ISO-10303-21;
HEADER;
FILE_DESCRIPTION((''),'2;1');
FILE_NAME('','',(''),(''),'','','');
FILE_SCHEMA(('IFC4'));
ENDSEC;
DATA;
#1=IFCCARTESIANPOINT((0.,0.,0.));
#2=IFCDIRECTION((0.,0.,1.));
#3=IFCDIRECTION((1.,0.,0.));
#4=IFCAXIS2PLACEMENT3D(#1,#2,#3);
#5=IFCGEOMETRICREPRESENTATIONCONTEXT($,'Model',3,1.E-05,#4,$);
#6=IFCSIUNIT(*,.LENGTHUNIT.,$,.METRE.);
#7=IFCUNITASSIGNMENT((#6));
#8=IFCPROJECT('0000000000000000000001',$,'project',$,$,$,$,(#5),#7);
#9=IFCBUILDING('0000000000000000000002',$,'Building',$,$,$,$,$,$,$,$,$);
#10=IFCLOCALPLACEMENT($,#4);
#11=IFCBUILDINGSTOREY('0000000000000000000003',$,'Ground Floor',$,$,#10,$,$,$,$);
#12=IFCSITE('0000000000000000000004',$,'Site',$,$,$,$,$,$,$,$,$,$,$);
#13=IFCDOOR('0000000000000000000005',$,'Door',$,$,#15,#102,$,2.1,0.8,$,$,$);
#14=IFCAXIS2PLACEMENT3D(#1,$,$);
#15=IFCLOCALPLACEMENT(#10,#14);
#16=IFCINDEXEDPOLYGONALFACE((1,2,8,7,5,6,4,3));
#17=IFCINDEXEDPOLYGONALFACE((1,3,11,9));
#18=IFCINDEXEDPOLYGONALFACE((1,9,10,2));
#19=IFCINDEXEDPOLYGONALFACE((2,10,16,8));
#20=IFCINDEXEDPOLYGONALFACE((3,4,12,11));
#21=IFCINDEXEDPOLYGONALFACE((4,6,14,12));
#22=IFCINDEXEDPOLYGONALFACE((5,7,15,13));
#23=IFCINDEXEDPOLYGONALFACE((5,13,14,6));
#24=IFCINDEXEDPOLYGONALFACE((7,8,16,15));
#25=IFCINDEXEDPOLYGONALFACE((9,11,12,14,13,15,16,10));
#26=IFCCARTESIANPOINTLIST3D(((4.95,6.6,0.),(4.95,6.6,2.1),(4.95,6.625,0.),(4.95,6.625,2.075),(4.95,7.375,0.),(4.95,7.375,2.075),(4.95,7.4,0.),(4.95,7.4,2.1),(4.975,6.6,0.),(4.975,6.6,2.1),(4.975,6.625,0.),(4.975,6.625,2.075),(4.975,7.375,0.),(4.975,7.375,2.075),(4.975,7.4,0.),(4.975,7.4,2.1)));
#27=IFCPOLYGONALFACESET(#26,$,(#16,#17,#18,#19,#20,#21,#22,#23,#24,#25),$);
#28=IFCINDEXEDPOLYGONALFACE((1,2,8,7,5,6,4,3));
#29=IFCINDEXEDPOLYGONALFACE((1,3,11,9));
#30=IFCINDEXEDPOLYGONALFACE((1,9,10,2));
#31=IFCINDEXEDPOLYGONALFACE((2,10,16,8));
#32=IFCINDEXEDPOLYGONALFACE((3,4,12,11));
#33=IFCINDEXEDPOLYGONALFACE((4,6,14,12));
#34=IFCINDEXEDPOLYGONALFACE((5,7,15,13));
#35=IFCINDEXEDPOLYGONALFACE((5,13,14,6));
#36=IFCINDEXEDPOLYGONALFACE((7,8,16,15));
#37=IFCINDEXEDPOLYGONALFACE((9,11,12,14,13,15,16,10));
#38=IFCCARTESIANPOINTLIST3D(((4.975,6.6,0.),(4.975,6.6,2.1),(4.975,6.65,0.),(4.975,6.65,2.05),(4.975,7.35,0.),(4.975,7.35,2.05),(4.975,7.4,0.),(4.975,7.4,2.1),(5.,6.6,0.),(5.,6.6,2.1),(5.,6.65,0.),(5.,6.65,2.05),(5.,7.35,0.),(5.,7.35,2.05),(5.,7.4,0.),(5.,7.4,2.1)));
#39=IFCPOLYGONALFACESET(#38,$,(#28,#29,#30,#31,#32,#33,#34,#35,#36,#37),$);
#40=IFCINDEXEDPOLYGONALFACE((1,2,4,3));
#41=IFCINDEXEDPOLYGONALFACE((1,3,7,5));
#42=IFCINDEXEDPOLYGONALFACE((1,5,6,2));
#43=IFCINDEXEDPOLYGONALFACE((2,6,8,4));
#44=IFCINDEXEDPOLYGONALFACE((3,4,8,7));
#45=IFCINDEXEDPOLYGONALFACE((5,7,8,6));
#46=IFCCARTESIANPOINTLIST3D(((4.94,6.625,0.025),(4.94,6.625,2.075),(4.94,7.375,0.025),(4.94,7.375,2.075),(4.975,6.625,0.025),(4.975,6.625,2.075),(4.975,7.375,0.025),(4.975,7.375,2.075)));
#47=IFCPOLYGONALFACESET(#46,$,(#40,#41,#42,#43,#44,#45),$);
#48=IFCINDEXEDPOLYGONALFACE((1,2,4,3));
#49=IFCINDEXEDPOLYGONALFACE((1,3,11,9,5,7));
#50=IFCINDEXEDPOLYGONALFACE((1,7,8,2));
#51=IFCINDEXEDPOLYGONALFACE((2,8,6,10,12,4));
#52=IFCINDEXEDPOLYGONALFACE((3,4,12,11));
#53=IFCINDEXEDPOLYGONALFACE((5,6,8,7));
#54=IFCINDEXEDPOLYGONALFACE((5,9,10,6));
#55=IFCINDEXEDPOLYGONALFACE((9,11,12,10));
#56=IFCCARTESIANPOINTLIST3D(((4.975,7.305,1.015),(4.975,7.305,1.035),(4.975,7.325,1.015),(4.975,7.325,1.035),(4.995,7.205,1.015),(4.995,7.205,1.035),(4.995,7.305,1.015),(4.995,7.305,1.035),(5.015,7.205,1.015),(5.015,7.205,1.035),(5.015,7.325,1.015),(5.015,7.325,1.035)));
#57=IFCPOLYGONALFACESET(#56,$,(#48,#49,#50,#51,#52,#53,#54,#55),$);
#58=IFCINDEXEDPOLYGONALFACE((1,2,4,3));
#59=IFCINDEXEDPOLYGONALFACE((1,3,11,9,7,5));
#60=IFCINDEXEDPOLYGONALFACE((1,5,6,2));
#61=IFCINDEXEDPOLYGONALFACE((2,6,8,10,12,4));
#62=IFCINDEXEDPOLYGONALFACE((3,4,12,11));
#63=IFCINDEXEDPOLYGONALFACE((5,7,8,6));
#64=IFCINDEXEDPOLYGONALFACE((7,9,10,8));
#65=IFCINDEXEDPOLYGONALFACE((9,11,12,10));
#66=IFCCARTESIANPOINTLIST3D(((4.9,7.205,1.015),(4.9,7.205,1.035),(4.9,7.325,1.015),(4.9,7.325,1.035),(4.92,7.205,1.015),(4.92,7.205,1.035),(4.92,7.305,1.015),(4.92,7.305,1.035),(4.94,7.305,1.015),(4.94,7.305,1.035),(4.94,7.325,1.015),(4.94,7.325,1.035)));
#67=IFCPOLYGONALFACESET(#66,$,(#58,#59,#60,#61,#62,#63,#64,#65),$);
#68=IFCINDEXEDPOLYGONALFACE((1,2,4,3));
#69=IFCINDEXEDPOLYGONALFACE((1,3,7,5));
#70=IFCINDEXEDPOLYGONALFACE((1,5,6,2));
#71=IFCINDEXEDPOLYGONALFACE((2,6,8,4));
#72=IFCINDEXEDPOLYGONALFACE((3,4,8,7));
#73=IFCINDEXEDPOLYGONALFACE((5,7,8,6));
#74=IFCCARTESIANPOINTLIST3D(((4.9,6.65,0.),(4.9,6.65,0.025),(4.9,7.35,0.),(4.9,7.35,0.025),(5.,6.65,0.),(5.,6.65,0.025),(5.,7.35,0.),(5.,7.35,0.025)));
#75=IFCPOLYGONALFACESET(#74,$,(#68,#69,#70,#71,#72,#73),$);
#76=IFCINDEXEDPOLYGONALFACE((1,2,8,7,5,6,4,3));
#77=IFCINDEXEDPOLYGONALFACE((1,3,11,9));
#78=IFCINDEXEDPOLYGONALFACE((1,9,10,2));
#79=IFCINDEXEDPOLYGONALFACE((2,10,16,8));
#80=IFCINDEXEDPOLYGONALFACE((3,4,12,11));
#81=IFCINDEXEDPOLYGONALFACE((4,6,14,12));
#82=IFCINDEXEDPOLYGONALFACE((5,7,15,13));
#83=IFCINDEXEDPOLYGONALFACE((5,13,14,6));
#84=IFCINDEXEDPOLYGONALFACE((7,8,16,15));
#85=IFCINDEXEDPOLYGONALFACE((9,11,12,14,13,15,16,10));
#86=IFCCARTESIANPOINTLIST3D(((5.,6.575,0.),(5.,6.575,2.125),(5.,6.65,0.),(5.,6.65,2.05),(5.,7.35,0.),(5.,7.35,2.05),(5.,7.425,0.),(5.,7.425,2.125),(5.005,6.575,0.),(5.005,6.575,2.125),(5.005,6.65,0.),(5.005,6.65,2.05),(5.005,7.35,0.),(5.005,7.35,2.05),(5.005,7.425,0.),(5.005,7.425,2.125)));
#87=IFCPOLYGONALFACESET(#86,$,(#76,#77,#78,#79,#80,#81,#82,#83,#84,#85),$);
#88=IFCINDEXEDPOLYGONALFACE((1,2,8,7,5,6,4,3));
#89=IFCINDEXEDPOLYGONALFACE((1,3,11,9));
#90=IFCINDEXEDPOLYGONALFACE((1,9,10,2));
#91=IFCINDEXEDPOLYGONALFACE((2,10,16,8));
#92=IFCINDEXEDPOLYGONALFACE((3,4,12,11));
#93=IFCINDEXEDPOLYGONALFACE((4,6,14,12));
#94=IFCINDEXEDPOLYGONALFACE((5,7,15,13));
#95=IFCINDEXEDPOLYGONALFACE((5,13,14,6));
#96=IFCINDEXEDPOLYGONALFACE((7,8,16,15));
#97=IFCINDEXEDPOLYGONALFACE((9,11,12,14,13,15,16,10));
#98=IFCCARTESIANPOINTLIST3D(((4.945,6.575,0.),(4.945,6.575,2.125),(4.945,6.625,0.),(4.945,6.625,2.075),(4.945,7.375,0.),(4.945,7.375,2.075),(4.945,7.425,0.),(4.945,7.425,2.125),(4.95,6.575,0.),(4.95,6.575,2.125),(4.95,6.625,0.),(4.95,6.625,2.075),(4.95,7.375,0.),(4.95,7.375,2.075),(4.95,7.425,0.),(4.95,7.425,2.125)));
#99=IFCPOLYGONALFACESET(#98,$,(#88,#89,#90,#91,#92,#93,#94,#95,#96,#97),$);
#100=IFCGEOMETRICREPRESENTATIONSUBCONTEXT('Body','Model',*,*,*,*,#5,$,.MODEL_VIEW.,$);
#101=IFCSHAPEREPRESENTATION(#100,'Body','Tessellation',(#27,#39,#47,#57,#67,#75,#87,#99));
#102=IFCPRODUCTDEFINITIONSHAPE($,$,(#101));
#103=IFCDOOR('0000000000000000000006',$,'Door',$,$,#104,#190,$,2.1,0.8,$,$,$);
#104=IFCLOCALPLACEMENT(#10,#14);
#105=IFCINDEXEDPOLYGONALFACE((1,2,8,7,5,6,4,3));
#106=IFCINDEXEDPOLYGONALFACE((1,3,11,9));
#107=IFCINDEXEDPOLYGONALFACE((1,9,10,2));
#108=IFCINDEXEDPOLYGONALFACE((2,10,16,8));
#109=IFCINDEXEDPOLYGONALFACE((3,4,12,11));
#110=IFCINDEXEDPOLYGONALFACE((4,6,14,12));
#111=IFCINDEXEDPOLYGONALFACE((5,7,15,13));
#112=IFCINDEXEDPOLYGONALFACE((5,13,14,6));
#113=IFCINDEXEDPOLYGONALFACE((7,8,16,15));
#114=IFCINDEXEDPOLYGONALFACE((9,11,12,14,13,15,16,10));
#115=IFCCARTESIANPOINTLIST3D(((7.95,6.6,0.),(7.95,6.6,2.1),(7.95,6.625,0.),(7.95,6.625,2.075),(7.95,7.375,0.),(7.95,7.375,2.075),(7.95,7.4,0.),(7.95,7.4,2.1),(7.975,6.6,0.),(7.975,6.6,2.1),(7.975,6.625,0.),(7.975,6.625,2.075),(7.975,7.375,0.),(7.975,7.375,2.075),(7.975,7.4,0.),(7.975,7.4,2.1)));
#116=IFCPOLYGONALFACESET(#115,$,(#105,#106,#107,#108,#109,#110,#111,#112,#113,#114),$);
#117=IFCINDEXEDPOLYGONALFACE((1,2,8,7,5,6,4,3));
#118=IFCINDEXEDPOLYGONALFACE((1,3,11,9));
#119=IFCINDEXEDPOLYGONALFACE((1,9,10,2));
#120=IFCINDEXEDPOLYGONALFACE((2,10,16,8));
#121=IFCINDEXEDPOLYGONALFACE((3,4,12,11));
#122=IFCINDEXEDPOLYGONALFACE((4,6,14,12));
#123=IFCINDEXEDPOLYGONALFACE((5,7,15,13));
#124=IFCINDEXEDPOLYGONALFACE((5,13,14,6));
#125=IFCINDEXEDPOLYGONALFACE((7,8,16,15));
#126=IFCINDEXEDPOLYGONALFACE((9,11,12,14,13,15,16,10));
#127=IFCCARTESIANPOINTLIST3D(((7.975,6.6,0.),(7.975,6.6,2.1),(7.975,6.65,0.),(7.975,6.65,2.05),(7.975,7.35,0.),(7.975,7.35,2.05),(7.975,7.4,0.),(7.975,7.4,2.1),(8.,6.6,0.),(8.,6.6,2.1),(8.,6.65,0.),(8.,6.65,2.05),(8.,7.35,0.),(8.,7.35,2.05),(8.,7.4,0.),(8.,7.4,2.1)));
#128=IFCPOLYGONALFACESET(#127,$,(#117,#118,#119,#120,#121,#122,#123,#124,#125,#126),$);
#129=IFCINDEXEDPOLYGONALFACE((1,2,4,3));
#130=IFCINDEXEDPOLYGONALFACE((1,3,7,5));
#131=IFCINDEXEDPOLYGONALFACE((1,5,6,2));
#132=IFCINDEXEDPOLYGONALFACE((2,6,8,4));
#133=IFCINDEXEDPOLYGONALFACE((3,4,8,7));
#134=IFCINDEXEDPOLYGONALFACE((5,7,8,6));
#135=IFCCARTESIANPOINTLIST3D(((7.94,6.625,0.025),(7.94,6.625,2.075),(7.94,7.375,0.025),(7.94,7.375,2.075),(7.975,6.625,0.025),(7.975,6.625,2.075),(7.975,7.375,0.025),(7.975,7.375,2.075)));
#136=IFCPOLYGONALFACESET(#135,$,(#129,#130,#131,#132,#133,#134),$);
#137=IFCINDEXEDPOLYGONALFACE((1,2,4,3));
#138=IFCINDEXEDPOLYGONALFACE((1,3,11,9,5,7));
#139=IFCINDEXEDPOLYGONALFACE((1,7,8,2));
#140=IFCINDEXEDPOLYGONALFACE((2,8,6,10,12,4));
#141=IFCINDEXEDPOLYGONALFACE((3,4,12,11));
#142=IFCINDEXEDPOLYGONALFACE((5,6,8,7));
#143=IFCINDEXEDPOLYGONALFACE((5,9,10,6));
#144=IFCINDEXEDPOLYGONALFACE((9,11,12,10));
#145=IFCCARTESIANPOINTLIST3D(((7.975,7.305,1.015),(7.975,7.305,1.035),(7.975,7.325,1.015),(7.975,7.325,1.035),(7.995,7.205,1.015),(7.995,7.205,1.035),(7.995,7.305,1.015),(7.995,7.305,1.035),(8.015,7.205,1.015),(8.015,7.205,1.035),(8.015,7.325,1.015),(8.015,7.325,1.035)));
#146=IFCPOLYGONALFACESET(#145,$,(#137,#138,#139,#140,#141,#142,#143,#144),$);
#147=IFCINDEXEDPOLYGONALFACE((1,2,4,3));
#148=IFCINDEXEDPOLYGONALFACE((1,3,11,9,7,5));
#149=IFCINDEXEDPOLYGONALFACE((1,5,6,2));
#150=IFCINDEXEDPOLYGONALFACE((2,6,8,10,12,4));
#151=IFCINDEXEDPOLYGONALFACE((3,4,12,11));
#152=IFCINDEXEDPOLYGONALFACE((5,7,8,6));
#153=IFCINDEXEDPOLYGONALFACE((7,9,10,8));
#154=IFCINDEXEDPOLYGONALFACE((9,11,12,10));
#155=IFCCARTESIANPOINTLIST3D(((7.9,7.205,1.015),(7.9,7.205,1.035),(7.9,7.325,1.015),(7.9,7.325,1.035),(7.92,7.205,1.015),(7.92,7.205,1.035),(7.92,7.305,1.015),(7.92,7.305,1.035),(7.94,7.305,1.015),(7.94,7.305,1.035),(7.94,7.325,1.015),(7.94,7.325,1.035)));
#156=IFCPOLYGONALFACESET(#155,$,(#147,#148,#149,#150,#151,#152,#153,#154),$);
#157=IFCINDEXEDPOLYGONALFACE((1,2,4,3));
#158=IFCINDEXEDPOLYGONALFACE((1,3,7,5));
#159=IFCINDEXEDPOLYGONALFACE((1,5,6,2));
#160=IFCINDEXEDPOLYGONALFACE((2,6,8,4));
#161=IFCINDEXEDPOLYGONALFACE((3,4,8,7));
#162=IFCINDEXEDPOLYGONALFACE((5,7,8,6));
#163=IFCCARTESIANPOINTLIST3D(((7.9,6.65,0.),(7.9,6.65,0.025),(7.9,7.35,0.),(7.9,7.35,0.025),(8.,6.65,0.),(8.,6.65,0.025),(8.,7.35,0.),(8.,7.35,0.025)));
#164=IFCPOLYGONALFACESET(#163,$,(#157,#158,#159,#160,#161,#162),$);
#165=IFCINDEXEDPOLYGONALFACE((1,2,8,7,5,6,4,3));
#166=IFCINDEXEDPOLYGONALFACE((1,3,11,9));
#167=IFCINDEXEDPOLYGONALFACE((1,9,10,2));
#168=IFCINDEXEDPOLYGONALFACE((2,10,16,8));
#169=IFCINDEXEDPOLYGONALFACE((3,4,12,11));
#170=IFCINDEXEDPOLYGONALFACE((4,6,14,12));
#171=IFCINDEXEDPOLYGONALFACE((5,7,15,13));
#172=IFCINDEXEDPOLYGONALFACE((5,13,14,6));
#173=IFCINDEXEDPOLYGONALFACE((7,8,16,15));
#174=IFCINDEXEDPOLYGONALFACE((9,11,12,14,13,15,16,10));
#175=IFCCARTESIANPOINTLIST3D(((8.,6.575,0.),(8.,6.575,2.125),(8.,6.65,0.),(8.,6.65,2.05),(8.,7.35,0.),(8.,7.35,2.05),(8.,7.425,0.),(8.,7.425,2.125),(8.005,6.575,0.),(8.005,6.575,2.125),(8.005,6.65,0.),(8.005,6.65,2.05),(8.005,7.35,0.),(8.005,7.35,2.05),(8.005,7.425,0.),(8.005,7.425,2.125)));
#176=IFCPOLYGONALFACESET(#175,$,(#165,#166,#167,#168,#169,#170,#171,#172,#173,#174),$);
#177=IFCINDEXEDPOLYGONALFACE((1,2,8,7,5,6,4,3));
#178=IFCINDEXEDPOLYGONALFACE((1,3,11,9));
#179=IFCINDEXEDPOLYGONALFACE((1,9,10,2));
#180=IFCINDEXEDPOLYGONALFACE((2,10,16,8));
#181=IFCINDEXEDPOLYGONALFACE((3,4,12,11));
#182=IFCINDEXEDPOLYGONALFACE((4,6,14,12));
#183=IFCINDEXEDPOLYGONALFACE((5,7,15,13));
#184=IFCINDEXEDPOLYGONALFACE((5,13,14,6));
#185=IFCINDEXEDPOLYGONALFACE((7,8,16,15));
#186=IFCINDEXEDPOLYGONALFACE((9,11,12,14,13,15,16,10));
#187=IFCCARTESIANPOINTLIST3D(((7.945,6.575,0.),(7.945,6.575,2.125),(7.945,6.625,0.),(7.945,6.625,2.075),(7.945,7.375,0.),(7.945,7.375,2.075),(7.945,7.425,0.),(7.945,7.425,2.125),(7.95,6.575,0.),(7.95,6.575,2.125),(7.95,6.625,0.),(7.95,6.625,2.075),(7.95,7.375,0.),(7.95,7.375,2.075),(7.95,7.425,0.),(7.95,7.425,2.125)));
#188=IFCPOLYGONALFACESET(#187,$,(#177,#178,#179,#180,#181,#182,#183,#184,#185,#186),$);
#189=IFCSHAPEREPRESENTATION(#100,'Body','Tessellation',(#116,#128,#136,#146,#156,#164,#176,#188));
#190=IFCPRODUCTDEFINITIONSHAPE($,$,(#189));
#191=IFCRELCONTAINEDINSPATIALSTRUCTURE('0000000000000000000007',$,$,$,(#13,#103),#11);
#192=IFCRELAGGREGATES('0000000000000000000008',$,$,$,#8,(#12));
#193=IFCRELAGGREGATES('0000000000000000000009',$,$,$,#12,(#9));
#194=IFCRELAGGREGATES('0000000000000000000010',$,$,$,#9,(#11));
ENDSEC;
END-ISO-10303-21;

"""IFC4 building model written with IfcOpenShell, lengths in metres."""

from ifc_helpers import new_model, si_unit, frame, origin_with_axes, place, context, subcontext, project, spatial, line, indexed_curve, outline, extrude, element, save


model = new_model("IFC4")

# Units and contexts
model_context = context("Model", 3, precision=1e-05, world=origin_with_axes())
body_context = subcontext(model_context, "Body", "Model", "MODEL_VIEW")
ifc_project = project(units=[si_unit("LENGTHUNIT", "METRE")], contexts=[model_context])

# Site, building, storey
site = spatial("IfcSite", under=ifc_project, Name="Site")
building = spatial("IfcBuilding", under=site, Name="Building")
storey_placement = place(None, origin_with_axes())
storey = spatial("IfcBuildingStorey", under=building, at=storey_placement, Name="Ground Floor")

# Doors
door_1_placement = place(storey_placement, frame((5.0, 6.6, 0.0), z_axis=(0.0, 0.0, 1.0), x_axis=(0.0, 1.0, 0.0)))
element("IfcDoor", 1, at=door_1_placement, inside=storey, Name="Door", OverallHeight=2.1, OverallWidth=0.8, context=body_context, shape_type="SweptSolid", body=[
    extrude(outline(indexed_curve([(0.0, 0.0), (0.0, 2.1), (0.8, 2.1), (0.8, 0.0), (0.775, 0.0), (0.775, 2.075), (0.025, 2.075), (0.025, 0.0)], segments=[line(1, 2, 3, 4, 5, 6, 7, 8, 1)])), frame((0.0, 0.025, 0.0), z_axis=(0.0, -1.0, 0.0), x_axis=(1.0, 0.0, 0.0)), (0.0, 0.0, -1.0), 0.025),
    extrude(outline(indexed_curve([(0.0, 0.0), (0.0, 2.1), (0.8, 2.1), (0.8, 0.0), (0.75, 0.0), (0.75, 2.05), (0.05, 2.05), (0.05, 0.0)], segments=[line(1, 2, 3, 4, 5, 6, 7, 8, 1)])), frame((0.0, 0.0, 0.0), z_axis=(0.0, -1.0, 0.0), x_axis=(1.0, 0.0, 0.0)), (0.0, 0.0, -1.0), 0.025),
    extrude(outline(indexed_curve([(0.0, 0.0), (0.75, 0.0), (0.75, 0.035), (0.0, 0.035)], segments=[line(1, 2, 3, 4, 1)])), frame((0.025, 0.025, 0.025), z_axis=(0.0, 0.0, 1.0), x_axis=(1.0, 0.0, 0.0)), (0.0, 0.0, 1.0), 2.05),
    extrude(outline(indexed_curve([(0.0, 0.0), (0.0, -0.04), (-0.12, -0.04), (-0.12, -0.02), (-0.02, -0.02), (-0.02, 0.0)], segments=[line(1, 2, 3, 4, 5, 6, 1)])), frame((0.725, 0.025, 1.015), z_axis=(0.0, 0.0, 1.0), x_axis=(1.0, 0.0, 0.0)), (0.0, 0.0, 1.0), 0.02),
    extrude(outline(indexed_curve([(0.0, 0.0), (0.0, 0.04), (-0.12, 0.04), (-0.12, 0.02), (-0.02, 0.02), (-0.02, 0.0)], segments=[line(1, 2, 3, 4, 5, 6, 1)])), frame((0.725, 0.06, 1.015), z_axis=(0.0, 0.0, 1.0), x_axis=(1.0, 0.0, 0.0)), (0.0, 0.0, 1.0), 0.02),
    extrude(outline(indexed_curve([(0.0, 0.0), (0.7, 0.0), (0.7, 0.1), (0.0, 0.1)], segments=[line(1, 2, 3, 4, 1)])), frame((0.05, 0.0, 0.0), z_axis=(0.0, 0.0, 1.0), x_axis=(1.0, 0.0, 0.0)), (0.0, 0.0, 1.0), 0.025),
    extrude(outline(indexed_curve([(0.0, 0.0), (0.0, 2.125), (0.85, 2.125), (0.85, 0.0), (0.775, 0.0), (0.775, 2.05), (0.075, 2.05), (0.075, 0.0)], segments=[line(1, 2, 3, 4, 5, 6, 7, 8, 1)])), frame((-0.025, -0.005, 0.0), z_axis=(0.0, -1.0, 0.0), x_axis=(1.0, 0.0, 0.0)), (0.0, 0.0, -1.0), 0.005),
    extrude(outline(indexed_curve([(0.0, 0.0), (0.0, 2.125), (0.85, 2.125), (0.85, 0.0), (0.8, 0.0), (0.8, 2.075), (0.05, 2.075), (0.05, 0.0)], segments=[line(1, 2, 3, 4, 5, 6, 7, 8, 1)])), frame((-0.025, 0.05, 0.0), z_axis=(0.0, -1.0, 0.0), x_axis=(1.0, 0.0, 0.0)), (0.0, 0.0, -1.0), 0.005),
])
door_2_placement = place(storey_placement, frame((8.0, 6.6, 0.0), z_axis=(0.0, 0.0, 1.0), x_axis=(0.0, 1.0, 0.0)))
element("IfcDoor", 2, at=door_2_placement, inside=storey, Name="Door", OverallHeight=2.1, OverallWidth=0.8, context=body_context, shape_type="SweptSolid", body=[
    extrude(outline(indexed_curve([(0.0, 0.0), (0.0, 2.1), (0.8, 2.1), (0.8, 0.0), (0.775, 0.0), (0.775, 2.075), (0.025, 2.075), (0.025, 0.0)], segments=[line(1, 2, 3, 4, 5, 6, 7, 8, 1)])), frame((0.0, 0.025, 0.0), z_axis=(0.0, -1.0, 0.0), x_axis=(1.0, 0.0, 0.0)), (0.0, 0.0, -1.0), 0.025),
    extrude(outline(indexed_curve([(0.0, 0.0), (0.0, 2.1), (0.8, 2.1), (0.8, 0.0), (0.75, 0.0), (0.75, 2.05), (0.05, 2.05), (0.05, 0.0)], segments=[line(1, 2, 3, 4, 5, 6, 7, 8, 1)])), frame((0.0, 0.0, 0.0), z_axis=(0.0, -1.0, 0.0), x_axis=(1.0, 0.0, 0.0)), (0.0, 0.0, -1.0), 0.025),
    extrude(outline(indexed_curve([(0.0, 0.0), (0.75, 0.0), (0.75, 0.035), (0.0, 0.035)], segments=[line(1, 2, 3, 4, 1)])), frame((0.025, 0.025, 0.025), z_axis=(0.0, 0.0, 1.0), x_axis=(1.0, 0.0, 0.0)), (0.0, 0.0, 1.0), 2.05),
    extrude(outline(indexed_curve([(0.0, 0.0), (0.0, -0.04), (-0.12, -0.04), (-0.12, -0.02), (-0.02, -0.02), (-0.02, 0.0)], segments=[line(1, 2, 3, 4, 5, 6, 1)])), frame((0.725, 0.025, 1.015), z_axis=(0.0, 0.0, 1.0), x_axis=(1.0, 0.0, 0.0)), (0.0, 0.0, 1.0), 0.02),
    extrude(outline(indexed_curve([(0.0, 0.0), (0.0, 0.04), (-0.12, 0.04), (-0.12, 0.02), (-0.02, 0.02), (-0.02, 0.0)], segments=[line(1, 2, 3, 4, 5, 6, 1)])), frame((0.725, 0.06, 1.015), z_axis=(0.0, 0.0, 1.0), x_axis=(1.0, 0.0, 0.0)), (0.0, 0.0, 1.0), 0.02),
    extrude(outline(indexed_curve([(0.0, 0.0), (0.7, 0.0), (0.7, 0.1), (0.0, 0.1)], segments=[line(1, 2, 3, 4, 1)])), frame((0.05, 0.0, 0.0), z_axis=(0.0, 0.0, 1.0), x_axis=(1.0, 0.0, 0.0)), (0.0, 0.0, 1.0), 0.025),
    extrude(outline(indexed_curve([(0.0, 0.0), (0.0, 2.125), (0.85, 2.125), (0.85, 0.0), (0.775, 0.0), (0.775, 2.05), (0.075, 2.05), (0.075, 0.0)], segments=[line(1, 2, 3, 4, 5, 6, 7, 8, 1)])), frame((-0.025, -0.005, 0.0), z_axis=(0.0, -1.0, 0.0), x_axis=(1.0, 0.0, 0.0)), (0.0, 0.0, -1.0), 0.005),
    extrude(outline(indexed_curve([(0.0, 0.0), (0.0, 2.125), (0.85, 2.125), (0.85, 0.0), (0.8, 0.0), (0.8, 2.075), (0.05, 2.075), (0.05, 0.0)], segments=[line(1, 2, 3, 4, 5, 6, 7, 8, 1)])), frame((-0.025, 0.05, 0.0), z_axis=(0.0, -1.0, 0.0), x_axis=(1.0, 0.0, 0.0)), (0.0, 0.0, -1.0), 0.005),
])

save(model, "model.ifc")
